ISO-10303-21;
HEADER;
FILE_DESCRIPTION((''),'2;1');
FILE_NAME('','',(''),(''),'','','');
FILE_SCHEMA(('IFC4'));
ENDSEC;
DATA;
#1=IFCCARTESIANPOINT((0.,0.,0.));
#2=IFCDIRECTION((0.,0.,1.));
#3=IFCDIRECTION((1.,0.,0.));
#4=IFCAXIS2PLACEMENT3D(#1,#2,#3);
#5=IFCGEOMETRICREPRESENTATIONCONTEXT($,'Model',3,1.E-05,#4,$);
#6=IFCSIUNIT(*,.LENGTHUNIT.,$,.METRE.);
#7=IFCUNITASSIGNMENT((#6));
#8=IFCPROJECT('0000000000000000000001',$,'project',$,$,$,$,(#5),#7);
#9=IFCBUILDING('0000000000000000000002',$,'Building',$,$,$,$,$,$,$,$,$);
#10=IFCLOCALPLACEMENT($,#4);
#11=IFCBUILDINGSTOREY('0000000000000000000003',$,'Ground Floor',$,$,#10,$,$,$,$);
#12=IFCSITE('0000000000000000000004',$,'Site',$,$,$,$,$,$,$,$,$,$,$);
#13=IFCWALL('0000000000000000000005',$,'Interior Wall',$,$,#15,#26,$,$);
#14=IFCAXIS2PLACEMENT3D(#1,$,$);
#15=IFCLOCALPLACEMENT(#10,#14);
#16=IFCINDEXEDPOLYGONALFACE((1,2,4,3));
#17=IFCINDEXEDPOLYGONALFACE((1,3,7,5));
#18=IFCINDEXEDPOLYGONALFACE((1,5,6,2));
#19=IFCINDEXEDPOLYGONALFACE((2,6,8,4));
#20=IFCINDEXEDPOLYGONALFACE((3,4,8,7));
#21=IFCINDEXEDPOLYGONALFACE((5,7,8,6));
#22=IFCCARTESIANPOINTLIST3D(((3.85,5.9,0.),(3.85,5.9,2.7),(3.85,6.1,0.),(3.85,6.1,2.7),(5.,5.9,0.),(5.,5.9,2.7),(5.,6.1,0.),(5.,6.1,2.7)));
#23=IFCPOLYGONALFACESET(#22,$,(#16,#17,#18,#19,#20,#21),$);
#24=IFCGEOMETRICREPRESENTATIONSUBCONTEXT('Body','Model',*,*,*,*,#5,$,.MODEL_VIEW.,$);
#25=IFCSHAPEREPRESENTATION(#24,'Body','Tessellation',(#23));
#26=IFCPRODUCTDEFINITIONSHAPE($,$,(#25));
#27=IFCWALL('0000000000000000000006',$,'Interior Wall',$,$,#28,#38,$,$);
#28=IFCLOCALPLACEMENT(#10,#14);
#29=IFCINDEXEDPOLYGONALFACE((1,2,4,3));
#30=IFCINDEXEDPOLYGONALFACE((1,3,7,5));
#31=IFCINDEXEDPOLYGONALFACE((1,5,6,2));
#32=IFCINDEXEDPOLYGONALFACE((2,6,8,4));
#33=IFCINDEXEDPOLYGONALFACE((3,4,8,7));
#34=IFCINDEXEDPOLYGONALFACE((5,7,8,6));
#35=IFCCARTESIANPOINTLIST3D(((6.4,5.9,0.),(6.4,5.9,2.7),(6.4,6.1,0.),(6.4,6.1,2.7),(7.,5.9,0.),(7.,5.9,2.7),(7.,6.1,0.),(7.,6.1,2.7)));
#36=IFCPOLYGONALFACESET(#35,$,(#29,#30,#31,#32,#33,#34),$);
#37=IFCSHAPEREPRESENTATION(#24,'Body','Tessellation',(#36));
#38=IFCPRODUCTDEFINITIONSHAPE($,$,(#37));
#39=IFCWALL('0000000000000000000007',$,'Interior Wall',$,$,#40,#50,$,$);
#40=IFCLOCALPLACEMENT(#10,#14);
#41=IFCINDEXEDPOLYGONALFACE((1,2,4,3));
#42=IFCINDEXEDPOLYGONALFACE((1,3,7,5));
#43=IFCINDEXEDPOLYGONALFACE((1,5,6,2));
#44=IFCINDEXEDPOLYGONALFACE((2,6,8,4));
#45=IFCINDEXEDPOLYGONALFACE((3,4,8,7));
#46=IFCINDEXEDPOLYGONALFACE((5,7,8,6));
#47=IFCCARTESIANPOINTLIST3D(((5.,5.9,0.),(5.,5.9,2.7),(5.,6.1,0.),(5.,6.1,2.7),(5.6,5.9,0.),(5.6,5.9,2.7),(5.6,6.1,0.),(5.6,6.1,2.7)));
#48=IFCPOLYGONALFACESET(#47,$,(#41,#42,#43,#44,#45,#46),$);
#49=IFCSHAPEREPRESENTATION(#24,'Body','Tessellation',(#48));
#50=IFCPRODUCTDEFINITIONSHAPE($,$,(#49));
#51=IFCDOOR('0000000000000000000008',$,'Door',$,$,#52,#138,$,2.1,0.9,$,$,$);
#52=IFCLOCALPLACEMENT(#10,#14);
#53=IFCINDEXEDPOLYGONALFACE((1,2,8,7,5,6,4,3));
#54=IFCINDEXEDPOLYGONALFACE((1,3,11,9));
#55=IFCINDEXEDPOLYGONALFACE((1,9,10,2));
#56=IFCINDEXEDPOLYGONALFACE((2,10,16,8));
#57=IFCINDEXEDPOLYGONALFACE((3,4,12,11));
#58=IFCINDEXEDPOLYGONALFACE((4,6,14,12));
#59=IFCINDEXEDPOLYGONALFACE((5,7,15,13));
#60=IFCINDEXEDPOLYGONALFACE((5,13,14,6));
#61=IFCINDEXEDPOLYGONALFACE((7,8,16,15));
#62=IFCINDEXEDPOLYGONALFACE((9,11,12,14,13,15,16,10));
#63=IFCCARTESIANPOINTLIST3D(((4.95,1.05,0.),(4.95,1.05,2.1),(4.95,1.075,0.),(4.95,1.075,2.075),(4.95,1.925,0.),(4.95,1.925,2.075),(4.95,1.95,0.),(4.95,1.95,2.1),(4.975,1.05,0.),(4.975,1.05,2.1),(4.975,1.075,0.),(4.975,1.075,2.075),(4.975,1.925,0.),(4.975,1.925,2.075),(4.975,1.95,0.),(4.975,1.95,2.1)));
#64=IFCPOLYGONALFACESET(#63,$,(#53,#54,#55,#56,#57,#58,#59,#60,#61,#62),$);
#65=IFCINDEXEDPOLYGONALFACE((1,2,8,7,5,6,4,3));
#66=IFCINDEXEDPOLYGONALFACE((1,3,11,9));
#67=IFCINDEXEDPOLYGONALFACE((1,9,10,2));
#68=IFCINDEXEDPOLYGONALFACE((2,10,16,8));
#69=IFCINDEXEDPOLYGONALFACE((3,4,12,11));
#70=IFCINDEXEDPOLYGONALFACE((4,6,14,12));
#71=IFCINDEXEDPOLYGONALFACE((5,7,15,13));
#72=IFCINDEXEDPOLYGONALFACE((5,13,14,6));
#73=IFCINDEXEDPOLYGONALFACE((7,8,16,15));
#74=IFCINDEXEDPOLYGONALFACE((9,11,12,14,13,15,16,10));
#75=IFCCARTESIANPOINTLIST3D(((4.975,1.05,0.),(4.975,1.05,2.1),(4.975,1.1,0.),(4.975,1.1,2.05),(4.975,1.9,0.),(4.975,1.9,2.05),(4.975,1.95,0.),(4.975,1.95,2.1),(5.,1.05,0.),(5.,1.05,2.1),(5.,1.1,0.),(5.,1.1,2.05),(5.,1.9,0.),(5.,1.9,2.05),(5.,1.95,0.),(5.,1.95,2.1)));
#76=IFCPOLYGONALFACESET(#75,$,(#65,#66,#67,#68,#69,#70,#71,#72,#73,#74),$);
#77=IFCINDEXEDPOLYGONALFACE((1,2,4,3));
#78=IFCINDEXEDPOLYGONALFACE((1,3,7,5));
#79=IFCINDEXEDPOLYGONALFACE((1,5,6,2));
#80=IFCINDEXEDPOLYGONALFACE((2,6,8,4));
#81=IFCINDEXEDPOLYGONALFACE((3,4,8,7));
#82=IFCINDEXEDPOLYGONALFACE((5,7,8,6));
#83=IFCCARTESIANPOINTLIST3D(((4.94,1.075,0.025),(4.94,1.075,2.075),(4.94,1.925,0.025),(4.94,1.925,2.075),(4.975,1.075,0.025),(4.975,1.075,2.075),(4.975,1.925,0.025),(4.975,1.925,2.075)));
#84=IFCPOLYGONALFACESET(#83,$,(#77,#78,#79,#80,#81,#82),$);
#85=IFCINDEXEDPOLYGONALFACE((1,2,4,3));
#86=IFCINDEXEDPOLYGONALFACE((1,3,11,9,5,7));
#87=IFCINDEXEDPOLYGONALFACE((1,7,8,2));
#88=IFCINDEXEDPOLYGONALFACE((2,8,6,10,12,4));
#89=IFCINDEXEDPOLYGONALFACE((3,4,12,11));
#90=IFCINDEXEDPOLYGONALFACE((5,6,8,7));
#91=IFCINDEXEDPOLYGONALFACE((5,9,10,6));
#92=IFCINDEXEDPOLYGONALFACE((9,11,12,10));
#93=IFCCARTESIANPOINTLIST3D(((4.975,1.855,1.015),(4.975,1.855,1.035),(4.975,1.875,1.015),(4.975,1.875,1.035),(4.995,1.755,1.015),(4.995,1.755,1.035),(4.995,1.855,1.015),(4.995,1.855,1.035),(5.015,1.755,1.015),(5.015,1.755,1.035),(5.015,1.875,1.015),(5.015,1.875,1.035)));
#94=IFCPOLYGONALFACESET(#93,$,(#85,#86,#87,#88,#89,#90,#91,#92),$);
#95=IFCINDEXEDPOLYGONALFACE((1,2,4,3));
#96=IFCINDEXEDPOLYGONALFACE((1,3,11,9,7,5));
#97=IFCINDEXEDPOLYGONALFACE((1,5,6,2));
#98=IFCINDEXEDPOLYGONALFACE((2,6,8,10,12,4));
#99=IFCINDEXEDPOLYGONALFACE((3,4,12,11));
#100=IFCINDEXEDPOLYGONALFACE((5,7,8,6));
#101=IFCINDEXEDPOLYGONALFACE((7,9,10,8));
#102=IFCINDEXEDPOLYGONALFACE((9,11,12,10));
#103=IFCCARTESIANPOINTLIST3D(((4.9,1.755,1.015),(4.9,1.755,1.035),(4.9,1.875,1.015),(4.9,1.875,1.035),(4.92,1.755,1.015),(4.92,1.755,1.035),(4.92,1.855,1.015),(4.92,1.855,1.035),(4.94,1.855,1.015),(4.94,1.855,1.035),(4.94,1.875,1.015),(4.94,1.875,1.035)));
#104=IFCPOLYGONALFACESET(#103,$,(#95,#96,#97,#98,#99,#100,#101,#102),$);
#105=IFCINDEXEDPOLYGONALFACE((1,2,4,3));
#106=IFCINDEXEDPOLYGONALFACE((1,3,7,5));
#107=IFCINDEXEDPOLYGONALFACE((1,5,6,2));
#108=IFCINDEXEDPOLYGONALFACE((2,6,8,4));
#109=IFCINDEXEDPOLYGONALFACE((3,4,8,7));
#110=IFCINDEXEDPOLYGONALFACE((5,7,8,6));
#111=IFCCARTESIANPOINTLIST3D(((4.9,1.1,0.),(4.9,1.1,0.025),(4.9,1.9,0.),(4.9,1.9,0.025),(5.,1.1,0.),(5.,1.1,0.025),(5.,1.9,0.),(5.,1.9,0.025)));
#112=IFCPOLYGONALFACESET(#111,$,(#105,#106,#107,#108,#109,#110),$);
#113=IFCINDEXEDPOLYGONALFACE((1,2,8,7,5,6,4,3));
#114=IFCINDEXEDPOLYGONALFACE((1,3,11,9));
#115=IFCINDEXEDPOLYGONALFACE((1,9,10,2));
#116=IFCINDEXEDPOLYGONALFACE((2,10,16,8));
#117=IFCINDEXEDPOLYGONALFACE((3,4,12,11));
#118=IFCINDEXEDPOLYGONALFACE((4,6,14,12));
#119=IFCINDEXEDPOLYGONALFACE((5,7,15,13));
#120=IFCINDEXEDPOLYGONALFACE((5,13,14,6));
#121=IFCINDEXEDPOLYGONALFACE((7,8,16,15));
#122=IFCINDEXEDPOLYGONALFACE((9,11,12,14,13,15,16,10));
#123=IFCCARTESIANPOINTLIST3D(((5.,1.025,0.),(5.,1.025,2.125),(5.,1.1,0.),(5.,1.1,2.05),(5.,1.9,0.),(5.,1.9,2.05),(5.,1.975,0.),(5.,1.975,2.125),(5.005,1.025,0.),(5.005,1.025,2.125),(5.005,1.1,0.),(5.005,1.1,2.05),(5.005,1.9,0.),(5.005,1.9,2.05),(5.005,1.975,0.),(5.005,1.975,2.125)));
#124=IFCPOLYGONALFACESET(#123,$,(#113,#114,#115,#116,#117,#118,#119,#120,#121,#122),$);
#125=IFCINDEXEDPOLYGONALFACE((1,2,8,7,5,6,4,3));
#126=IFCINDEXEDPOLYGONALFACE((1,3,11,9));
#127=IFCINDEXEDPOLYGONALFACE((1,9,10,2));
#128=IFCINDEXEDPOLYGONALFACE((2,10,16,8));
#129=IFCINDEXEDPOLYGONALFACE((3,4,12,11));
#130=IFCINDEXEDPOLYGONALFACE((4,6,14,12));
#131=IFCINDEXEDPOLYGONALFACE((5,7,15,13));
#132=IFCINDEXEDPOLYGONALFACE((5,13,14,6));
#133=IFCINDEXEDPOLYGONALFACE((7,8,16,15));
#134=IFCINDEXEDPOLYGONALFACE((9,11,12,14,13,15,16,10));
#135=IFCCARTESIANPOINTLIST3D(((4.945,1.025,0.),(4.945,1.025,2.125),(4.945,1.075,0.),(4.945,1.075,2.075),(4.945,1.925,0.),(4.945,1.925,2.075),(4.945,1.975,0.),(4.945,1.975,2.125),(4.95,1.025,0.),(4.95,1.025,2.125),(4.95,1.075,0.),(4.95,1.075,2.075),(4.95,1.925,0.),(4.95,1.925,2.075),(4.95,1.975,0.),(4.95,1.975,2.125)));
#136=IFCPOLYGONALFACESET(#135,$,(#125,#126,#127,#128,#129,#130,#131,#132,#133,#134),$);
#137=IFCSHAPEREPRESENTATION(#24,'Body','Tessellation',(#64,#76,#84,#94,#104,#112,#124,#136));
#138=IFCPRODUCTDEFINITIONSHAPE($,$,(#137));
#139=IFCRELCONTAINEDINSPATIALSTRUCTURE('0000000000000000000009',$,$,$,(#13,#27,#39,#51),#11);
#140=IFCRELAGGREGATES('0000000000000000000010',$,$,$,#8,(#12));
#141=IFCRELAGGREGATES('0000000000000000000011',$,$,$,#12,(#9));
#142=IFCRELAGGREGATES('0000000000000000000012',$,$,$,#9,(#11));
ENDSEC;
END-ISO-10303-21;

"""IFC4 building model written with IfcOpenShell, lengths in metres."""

from ifc_helpers import new_model, si_unit, frame, origin_with_axes, place, context, subcontext, project, spatial, line, indexed_curve, outline, extrude, element, save


model = new_model("IFC4")

# Units and contexts
model_context = context("Model", 3, precision=1e-05, world=origin_with_axes())
body_context = subcontext(model_context, "Body", "Model", "MODEL_VIEW")
ifc_project = project(units=[si_unit("LENGTHUNIT", "METRE")], contexts=[model_context])

# Site, building, storey
site = spatial("IfcSite", under=ifc_project, Name="Site")
building = spatial("IfcBuilding", under=site, Name="Building")
storey_placement = place(None, origin_with_axes())
storey = spatial("IfcBuildingStorey", under=building, at=storey_placement, Name="Ground Floor")

# Walls
wall_1_placement = place(storey_placement, frame((5.0, 6.0, 0.0), z_axis=(0.0, 0.0, 1.0), x_axis=(-1.0, 0.0, 0.0)))
element("IfcWall", 1, at=wall_1_placement, inside=storey, Name="Interior Wall", context=body_context, shape_type="SweptSolid", body=[
    extrude(outline(indexed_curve([(0.0, 0.0), (0.0, 0.2), (1.15, 0.2), (1.15, 0.0), (0.0, 0.0)], self_intersect=False)), frame((0.0, -0.1, 0.0), z_axis=(0.0, 0.0, 1.0), x_axis=(1.0, 0.0, 0.0)), (0.0, 0.0, 1.0), 2.7),
])
for number, where, z_axis, x_axis, name in (
    (2, (7.0, 6.0, 0.0), (0.0, 0.0, 1.0), (-1.0, 0.0, 0.0), "Interior Wall"),
    (3, (5.6, 6.0, 0.0), (0.0, 0.0, 1.0), (-1.0, 0.0, 0.0), "Interior Wall"),
):
    element("IfcWall", number, at=place(storey_placement, frame(where, z_axis=z_axis, x_axis=x_axis)), inside=storey, Name=name, context=body_context, shape_type="SweptSolid", body=[
        extrude(outline(indexed_curve([(0.0, 0.0), (0.0, 0.2), (0.6, 0.2), (0.6, 0.0), (0.0, 0.0)], self_intersect=False)), frame((0.0, -0.1, 0.0), z_axis=(0.0, 0.0, 1.0), x_axis=(1.0, 0.0, 0.0)), (0.0, 0.0, 1.0), 2.7),
    ])

# Door
door_1_placement = place(storey_placement, frame((5.0, 1.05, 0.0), z_axis=(0.0, 0.0, 1.0), x_axis=(0.0, 1.0, 0.0)))
element("IfcDoor", 4, at=door_1_placement, inside=storey, Name="Door", OverallHeight=2.1, OverallWidth=0.9, context=body_context, shape_type="SweptSolid", body=[
    extrude(outline(indexed_curve([(0.0, 0.0), (0.0, 2.1), (0.9, 2.1), (0.9, 0.0), (0.875, 0.0), (0.875, 2.075), (0.025, 2.075), (0.025, 0.0)], segments=[line(1, 2, 3, 4, 5, 6, 7, 8, 1)])), frame((0.0, 0.025, 0.0), z_axis=(0.0, -1.0, 0.0), x_axis=(1.0, 0.0, 0.0)), (0.0, 0.0, -1.0), 0.025),
    extrude(outline(indexed_curve([(0.0, 0.0), (0.0, 2.1), (0.9, 2.1), (0.9, 0.0), (0.85, 0.0), (0.85, 2.05), (0.05, 2.05), (0.05, 0.0)], segments=[line(1, 2, 3, 4, 5, 6, 7, 8, 1)])), frame((0.0, 0.0, 0.0), z_axis=(0.0, -1.0, 0.0), x_axis=(1.0, 0.0, 0.0)), (0.0, 0.0, -1.0), 0.025),
    extrude(outline(indexed_curve([(0.0, 0.0), (0.85, 0.0), (0.85, 0.035), (0.0, 0.035)], segments=[line(1, 2, 3, 4, 1)])), frame((0.025, 0.025, 0.025), z_axis=(0.0, 0.0, 1.0), x_axis=(1.0, 0.0, 0.0)), (0.0, 0.0, 1.0), 2.05),
    extrude(outline(indexed_curve([(0.0, 0.0), (0.0, -0.04), (-0.12, -0.04), (-0.12, -0.02), (-0.02, -0.02), (-0.02, 0.0)], segments=[line(1, 2, 3, 4, 5, 6, 1)])), frame((0.825, 0.025, 1.015), z_axis=(0.0, 0.0, 1.0), x_axis=(1.0, 0.0, 0.0)), (0.0, 0.0, 1.0), 0.02),
    extrude(outline(indexed_curve([(0.0, 0.0), (0.0, 0.04), (-0.12, 0.04), (-0.12, 0.02), (-0.02, 0.02), (-0.02, 0.0)], segments=[line(1, 2, 3, 4, 5, 6, 1)])), frame((0.825, 0.06, 1.015), z_axis=(0.0, 0.0, 1.0), x_axis=(1.0, 0.0, 0.0)), (0.0, 0.0, 1.0), 0.02),
    extrude(outline(indexed_curve([(0.0, 0.0), (0.8, 0.0), (0.8, 0.1), (0.0, 0.1)], segments=[line(1, 2, 3, 4, 1)])), frame((0.05, 0.0, 0.0), z_axis=(0.0, 0.0, 1.0), x_axis=(1.0, 0.0, 0.0)), (0.0, 0.0, 1.0), 0.025),
    extrude(outline(indexed_curve([(0.0, 0.0), (0.0, 2.125), (0.95, 2.125), (0.95, 0.0), (0.875, 0.0), (0.875, 2.05), (0.075, 2.05), (0.075, 0.0)], segments=[line(1, 2, 3, 4, 5, 6, 7, 8, 1)])), frame((-0.025, -0.005, 0.0), z_axis=(0.0, -1.0, 0.0), x_axis=(1.0, 0.0, 0.0)), (0.0, 0.0, -1.0), 0.005),
    extrude(outline(indexed_curve([(0.0, 0.0), (0.0, 2.125), (0.95, 2.125), (0.95, 0.0), (0.9, 0.0), (0.9, 2.075), (0.05, 2.075), (0.05, 0.0)], segments=[line(1, 2, 3, 4, 5, 6, 7, 8, 1)])), frame((-0.025, 0.05, 0.0), z_axis=(0.0, -1.0, 0.0), x_axis=(1.0, 0.0, 0.0)), (0.0, 0.0, -1.0), 0.005),
])

save(model, "model.ifc")
